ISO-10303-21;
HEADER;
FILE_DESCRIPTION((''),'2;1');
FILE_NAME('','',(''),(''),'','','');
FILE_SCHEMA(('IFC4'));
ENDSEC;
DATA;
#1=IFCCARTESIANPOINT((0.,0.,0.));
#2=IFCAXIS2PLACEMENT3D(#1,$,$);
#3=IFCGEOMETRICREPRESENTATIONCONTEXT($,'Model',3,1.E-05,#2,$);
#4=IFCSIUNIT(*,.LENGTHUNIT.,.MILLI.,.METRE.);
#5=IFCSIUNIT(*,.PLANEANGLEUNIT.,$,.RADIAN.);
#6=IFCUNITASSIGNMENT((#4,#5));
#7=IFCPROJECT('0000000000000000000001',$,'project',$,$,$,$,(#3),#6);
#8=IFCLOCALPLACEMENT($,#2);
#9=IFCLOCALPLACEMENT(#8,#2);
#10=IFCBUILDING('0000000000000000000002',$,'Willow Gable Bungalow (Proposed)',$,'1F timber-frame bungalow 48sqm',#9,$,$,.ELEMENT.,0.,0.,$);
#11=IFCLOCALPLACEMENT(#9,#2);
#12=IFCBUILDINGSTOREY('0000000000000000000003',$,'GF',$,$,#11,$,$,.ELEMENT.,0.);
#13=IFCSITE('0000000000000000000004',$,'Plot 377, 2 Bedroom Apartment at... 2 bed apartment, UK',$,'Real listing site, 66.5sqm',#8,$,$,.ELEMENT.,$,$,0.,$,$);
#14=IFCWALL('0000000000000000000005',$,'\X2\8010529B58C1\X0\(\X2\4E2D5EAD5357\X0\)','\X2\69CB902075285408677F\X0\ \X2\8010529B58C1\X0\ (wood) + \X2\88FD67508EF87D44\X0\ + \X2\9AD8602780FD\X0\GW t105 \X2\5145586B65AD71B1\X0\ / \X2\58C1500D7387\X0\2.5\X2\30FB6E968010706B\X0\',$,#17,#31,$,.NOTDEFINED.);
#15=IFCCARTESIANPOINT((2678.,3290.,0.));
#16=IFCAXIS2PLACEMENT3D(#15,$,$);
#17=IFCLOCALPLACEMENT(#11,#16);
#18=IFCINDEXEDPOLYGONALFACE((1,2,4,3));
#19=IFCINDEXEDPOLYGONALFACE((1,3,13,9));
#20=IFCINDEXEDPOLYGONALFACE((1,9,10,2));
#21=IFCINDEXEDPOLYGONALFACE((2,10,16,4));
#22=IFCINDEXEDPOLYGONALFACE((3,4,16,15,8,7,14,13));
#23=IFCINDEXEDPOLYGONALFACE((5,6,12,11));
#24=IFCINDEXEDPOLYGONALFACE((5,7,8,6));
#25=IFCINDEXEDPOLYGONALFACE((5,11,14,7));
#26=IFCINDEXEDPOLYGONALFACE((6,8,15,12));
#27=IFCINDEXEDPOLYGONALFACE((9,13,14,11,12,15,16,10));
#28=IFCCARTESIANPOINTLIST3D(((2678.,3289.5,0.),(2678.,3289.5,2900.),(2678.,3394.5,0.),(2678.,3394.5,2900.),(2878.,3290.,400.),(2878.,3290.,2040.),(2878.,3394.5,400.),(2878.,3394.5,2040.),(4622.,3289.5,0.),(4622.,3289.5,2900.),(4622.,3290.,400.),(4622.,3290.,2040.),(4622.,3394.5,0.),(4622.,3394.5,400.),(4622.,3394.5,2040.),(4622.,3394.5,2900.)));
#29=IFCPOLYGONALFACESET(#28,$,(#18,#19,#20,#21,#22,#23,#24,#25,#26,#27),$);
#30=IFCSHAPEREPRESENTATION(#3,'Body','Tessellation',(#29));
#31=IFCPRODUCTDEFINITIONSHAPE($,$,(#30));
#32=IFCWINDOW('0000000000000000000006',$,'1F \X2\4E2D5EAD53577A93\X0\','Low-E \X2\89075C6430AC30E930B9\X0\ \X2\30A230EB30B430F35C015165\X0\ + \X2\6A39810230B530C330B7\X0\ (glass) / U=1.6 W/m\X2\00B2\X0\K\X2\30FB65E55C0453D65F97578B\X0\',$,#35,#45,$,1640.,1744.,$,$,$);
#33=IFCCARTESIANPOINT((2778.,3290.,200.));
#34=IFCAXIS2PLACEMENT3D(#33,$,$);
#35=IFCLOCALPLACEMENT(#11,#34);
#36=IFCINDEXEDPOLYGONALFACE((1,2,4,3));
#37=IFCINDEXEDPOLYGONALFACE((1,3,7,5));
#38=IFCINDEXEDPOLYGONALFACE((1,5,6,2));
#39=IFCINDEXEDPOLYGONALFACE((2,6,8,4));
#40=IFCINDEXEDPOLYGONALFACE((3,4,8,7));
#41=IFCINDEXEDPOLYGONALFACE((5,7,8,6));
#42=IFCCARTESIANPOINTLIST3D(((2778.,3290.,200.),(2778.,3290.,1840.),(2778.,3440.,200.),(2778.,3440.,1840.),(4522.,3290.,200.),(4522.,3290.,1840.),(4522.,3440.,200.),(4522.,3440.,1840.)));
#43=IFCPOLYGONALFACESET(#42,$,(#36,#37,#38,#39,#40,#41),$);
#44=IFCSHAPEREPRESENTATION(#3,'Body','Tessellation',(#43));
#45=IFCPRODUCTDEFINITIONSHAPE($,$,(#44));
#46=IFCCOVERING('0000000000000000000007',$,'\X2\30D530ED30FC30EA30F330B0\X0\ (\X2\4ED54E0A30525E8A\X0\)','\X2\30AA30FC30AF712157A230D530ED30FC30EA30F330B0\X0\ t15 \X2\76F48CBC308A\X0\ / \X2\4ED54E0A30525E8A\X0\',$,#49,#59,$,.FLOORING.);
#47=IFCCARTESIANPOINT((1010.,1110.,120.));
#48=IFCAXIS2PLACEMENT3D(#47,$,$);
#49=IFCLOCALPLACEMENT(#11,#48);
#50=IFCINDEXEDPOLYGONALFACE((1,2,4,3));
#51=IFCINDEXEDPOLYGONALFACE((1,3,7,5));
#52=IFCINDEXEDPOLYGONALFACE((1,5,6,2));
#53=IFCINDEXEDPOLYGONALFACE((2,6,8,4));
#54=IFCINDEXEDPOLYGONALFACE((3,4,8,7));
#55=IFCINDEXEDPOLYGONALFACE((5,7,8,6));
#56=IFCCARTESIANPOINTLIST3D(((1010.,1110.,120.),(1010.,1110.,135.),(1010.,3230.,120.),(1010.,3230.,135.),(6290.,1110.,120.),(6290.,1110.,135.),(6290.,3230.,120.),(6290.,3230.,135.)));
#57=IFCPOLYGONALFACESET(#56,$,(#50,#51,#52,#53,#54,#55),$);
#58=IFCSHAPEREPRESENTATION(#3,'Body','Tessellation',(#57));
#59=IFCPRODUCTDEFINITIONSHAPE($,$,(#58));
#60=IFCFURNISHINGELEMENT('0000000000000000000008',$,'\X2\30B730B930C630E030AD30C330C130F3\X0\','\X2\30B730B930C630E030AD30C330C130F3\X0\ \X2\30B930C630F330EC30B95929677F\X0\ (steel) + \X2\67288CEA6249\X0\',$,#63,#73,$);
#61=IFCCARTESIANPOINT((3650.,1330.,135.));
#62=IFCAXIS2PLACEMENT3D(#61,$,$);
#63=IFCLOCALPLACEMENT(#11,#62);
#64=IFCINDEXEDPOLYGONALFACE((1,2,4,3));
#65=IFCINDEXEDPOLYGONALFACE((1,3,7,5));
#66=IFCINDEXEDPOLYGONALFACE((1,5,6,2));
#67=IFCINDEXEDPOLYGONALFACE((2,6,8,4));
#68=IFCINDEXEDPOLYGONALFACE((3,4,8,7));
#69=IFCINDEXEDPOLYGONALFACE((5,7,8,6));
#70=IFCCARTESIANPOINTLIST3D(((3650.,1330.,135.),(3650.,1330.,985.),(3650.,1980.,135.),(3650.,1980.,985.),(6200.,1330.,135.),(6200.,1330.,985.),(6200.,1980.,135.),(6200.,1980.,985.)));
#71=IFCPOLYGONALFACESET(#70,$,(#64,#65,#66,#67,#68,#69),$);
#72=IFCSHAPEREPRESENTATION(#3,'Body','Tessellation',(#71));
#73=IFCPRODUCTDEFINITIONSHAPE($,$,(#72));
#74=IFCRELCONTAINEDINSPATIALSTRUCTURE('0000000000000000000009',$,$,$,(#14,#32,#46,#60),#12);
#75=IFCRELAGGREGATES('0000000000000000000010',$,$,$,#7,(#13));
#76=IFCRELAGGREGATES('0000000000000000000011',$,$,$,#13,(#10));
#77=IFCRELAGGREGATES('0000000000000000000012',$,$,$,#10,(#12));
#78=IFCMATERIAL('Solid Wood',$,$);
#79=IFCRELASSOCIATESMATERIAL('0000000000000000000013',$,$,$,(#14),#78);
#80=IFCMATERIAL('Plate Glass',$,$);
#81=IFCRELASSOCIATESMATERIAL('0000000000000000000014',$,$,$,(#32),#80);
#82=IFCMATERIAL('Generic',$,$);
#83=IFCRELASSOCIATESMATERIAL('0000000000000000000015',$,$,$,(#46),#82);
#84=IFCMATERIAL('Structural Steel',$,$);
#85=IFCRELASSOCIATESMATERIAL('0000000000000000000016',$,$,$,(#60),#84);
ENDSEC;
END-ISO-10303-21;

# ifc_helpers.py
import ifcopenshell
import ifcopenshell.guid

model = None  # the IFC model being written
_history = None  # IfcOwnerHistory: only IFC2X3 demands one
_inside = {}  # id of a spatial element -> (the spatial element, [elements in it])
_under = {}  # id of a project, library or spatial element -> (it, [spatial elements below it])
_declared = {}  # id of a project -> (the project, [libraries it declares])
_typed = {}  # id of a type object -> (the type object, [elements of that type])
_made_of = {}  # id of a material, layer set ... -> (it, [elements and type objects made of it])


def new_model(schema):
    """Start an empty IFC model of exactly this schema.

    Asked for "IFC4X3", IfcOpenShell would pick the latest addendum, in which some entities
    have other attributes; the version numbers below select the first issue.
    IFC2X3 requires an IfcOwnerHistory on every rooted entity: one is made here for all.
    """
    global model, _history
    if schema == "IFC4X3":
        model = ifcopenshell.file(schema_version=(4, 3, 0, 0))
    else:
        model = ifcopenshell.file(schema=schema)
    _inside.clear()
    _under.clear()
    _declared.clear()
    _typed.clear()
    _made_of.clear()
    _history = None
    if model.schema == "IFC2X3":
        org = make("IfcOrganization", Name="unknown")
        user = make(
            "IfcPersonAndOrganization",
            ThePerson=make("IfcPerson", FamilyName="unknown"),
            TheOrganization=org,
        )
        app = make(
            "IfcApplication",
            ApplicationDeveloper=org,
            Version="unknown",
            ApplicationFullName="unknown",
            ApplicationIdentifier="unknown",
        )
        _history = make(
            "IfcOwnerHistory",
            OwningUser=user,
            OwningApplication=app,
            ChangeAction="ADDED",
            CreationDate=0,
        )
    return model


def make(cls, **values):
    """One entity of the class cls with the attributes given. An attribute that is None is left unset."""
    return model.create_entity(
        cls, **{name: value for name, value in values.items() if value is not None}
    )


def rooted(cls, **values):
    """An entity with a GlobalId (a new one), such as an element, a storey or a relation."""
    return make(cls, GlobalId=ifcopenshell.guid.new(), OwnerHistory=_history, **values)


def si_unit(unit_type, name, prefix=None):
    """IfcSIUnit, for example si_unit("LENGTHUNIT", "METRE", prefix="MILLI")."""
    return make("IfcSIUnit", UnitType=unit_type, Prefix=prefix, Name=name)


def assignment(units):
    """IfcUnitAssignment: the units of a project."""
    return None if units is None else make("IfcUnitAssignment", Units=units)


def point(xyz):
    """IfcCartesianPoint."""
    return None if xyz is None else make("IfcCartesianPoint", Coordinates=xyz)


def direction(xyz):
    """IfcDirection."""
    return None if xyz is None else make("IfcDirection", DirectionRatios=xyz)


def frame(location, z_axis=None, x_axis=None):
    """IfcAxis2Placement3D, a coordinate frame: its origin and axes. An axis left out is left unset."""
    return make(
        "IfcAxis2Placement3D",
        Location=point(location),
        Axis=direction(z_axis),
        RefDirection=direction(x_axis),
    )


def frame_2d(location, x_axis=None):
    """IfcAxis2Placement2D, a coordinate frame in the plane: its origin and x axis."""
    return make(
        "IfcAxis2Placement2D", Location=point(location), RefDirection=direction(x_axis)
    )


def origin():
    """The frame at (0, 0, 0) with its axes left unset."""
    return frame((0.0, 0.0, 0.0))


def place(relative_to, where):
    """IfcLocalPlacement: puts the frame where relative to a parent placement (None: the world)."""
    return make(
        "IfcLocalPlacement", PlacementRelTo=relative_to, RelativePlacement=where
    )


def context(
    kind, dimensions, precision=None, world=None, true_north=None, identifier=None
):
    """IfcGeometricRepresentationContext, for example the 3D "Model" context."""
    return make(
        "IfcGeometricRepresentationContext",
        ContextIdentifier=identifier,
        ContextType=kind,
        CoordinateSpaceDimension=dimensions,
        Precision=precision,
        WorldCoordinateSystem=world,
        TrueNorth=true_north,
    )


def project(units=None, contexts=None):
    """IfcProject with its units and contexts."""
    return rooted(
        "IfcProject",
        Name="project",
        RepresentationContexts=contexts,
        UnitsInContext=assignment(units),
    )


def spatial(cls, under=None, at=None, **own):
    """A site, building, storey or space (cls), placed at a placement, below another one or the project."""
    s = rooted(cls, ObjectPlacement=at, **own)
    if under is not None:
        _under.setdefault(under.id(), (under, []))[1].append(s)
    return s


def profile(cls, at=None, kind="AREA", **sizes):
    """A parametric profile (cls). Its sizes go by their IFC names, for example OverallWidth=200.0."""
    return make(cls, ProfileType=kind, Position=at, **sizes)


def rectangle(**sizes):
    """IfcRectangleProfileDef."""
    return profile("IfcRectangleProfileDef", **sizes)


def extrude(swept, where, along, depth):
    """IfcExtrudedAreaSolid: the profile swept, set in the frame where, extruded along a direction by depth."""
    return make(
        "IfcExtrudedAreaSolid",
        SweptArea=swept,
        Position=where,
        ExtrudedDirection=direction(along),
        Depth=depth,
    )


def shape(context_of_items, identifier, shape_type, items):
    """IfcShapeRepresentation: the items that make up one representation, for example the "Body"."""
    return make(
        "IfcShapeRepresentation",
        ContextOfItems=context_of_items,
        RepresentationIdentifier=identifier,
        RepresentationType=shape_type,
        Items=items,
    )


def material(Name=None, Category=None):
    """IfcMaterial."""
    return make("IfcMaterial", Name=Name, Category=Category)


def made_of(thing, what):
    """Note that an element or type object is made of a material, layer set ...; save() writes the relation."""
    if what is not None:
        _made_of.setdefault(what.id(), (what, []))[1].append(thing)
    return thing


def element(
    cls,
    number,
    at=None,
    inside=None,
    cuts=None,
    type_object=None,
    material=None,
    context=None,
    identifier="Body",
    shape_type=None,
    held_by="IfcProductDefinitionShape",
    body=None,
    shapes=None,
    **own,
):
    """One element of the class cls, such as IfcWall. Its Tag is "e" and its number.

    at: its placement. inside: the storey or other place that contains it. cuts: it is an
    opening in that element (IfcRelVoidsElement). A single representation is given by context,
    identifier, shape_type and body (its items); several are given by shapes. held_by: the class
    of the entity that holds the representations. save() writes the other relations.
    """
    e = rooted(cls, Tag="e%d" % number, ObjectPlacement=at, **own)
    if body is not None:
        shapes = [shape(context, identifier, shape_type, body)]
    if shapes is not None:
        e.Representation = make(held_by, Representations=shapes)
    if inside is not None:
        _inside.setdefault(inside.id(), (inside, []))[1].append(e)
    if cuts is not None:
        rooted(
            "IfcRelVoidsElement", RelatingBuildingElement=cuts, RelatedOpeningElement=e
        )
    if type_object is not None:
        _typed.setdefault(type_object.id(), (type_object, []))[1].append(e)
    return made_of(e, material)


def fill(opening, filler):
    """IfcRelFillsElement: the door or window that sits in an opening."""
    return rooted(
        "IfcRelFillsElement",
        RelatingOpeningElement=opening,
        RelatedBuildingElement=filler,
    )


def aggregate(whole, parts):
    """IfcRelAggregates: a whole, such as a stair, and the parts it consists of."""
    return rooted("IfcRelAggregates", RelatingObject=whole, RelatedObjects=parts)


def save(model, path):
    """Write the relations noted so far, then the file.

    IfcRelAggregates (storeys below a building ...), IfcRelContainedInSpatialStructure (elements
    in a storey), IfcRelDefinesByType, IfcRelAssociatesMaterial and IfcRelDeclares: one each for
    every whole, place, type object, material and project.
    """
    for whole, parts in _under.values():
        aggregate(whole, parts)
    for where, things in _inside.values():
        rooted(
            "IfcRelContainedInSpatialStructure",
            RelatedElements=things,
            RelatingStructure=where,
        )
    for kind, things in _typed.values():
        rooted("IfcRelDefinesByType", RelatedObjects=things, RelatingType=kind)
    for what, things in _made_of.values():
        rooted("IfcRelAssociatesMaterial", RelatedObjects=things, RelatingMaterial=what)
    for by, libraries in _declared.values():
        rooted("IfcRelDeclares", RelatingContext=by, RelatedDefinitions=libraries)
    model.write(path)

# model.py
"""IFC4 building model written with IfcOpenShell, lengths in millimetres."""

from ifc_helpers import new_model, si_unit, frame, frame_2d, origin, place, context, project, spatial, rectangle, extrude, material, element, fill, save


model = new_model("IFC4")

# Units and contexts
model_context = context("Model", 3, precision=1e-05, world=origin())
ifc_project = project(units=[si_unit("LENGTHUNIT", "METRE", prefix="MILLI"), si_unit("PLANEANGLEUNIT", "RADIAN")], contexts=[model_context])

# Site, building, storey
site_placement = place(None, origin())
site = spatial("IfcSite", under=ifc_project, at=site_placement, Name="Plot 377, 2 Bedroom Apartment at... 2 bed apartment, UK", ObjectType="Real listing site, 66.5sqm", CompositionType="ELEMENT", RefElevation=0.0)
building_placement = place(site_placement, origin())
building = spatial("IfcBuilding", under=site, at=building_placement, Name="Willow Gable Bungalow (Proposed)", ObjectType="1F timber-frame bungalow 48sqm", CompositionType="ELEMENT", ElevationOfRefHeight=0.0, ElevationOfTerrain=0.0)
storey_placement = place(building_placement, origin())
storey = spatial("IfcBuildingStorey", under=building, at=storey_placement, Name="GF", CompositionType="ELEMENT", Elevation=0.0)

# Shared definitions
ifc_material_1 = material(Name="Solid Wood")
ifc_material_2 = material(Name="Generic")

# Shared definitions
ifc_material_3 = material(Name="Plate Glass")

# Wall, opening, window
wall_1_placement = place(storey_placement, frame((2678.0, 3290.0, 0.0)))
wall_1 = element("IfcWall", 1, at=wall_1_placement, inside=storey, material=ifc_material_1, Name="耐力壁(中庭南)", Description="構造用合板 耐力壁 (wood) + 製材軸組 + 高性能GW t105 充填断熱 / 壁倍率2.5・準耐火", PredefinedType="NOTDEFINED", context=model_context, shape_type="SweptSolid", body=[
    extrude(rectangle(XDim=1944.0, YDim=105.0, at=frame_2d((972.0, 52.0))), frame((2678.0, 3290.0, 0.0)), (0.0, 0.0, 1.0), 2900.0),
])
opening_1_placement = place(storey_placement, frame((2778.0, 3290.0, 200.0)))
opening_1 = element("IfcOpeningElement", 2, at=opening_1_placement, cuts=wall_1, PredefinedType="NOTDEFINED", context=model_context, shape_type="SweptSolid", body=[
    extrude(rectangle(XDim=1744.0, YDim=150.0, at=frame_2d((872.0, 75.0))), frame((2778.0, 3290.0, 200.0)), (0.0, 0.0, 1.0), 1640.0),
])
window_1_placement = place(storey_placement, frame((2778.0, 3290.0, 200.0)))
window_1 = element("IfcWindow", 3, at=window_1_placement, inside=storey, material=ifc_material_3, Name="1F 中庭南窓", Description="Low-E 複層ガラス アルゴン封入 + 樹脂サッシ (glass) / U=1.6 W/m²K・日射取得型", OverallHeight=1640.0, OverallWidth=1744.0, context=model_context, shape_type="SweptSolid", body=[
    extrude(rectangle(XDim=1744.0, YDim=150.0, at=frame_2d((872.0, 75.0))), frame((2778.0, 3290.0, 200.0)), (0.0, 0.0, 1.0), 1640.0),
])
fill(opening_1, window_1)

# Covering
covering_placement = place(storey_placement, frame((1010.0, 1110.0, 120.0)))
element("IfcCovering", 4, at=covering_placement, inside=storey, material=ifc_material_2, Name="フローリング (仕上げ床)", Description="オーク無垢フローリング t15 直貼り / 仕上げ床", PredefinedType="FLOORING", context=model_context, shape_type="SweptSolid", body=[
    extrude(rectangle(XDim=5280.0, YDim=2120.0, at=frame_2d((2640.0, 1060.0))), frame((1010.0, 1110.0, 120.0)), (0.0, 0.0, 1.0), 15.0),
])

# Furnishing element
ifc_material_4 = material(Name="Structural Steel")
furnishing_placement = place(storey_placement, frame((3650.0, 1330.0, 135.0)))
element("IfcFurnishingElement", 5, at=furnishing_placement, inside=storey, material=ifc_material_4, Name="システムキッチン", Description="システムキッチン ステンレス天板 (steel) + 木質扉", context=model_context, shape_type="SweptSolid", body=[
    extrude(rectangle(XDim=2550.0, YDim=650.0, at=frame_2d((1275.0, 325.0))), frame((3650.0, 1330.0, 135.0)), (0.0, 0.0, 1.0), 850.0),
])

save(model, "model.ifc")
